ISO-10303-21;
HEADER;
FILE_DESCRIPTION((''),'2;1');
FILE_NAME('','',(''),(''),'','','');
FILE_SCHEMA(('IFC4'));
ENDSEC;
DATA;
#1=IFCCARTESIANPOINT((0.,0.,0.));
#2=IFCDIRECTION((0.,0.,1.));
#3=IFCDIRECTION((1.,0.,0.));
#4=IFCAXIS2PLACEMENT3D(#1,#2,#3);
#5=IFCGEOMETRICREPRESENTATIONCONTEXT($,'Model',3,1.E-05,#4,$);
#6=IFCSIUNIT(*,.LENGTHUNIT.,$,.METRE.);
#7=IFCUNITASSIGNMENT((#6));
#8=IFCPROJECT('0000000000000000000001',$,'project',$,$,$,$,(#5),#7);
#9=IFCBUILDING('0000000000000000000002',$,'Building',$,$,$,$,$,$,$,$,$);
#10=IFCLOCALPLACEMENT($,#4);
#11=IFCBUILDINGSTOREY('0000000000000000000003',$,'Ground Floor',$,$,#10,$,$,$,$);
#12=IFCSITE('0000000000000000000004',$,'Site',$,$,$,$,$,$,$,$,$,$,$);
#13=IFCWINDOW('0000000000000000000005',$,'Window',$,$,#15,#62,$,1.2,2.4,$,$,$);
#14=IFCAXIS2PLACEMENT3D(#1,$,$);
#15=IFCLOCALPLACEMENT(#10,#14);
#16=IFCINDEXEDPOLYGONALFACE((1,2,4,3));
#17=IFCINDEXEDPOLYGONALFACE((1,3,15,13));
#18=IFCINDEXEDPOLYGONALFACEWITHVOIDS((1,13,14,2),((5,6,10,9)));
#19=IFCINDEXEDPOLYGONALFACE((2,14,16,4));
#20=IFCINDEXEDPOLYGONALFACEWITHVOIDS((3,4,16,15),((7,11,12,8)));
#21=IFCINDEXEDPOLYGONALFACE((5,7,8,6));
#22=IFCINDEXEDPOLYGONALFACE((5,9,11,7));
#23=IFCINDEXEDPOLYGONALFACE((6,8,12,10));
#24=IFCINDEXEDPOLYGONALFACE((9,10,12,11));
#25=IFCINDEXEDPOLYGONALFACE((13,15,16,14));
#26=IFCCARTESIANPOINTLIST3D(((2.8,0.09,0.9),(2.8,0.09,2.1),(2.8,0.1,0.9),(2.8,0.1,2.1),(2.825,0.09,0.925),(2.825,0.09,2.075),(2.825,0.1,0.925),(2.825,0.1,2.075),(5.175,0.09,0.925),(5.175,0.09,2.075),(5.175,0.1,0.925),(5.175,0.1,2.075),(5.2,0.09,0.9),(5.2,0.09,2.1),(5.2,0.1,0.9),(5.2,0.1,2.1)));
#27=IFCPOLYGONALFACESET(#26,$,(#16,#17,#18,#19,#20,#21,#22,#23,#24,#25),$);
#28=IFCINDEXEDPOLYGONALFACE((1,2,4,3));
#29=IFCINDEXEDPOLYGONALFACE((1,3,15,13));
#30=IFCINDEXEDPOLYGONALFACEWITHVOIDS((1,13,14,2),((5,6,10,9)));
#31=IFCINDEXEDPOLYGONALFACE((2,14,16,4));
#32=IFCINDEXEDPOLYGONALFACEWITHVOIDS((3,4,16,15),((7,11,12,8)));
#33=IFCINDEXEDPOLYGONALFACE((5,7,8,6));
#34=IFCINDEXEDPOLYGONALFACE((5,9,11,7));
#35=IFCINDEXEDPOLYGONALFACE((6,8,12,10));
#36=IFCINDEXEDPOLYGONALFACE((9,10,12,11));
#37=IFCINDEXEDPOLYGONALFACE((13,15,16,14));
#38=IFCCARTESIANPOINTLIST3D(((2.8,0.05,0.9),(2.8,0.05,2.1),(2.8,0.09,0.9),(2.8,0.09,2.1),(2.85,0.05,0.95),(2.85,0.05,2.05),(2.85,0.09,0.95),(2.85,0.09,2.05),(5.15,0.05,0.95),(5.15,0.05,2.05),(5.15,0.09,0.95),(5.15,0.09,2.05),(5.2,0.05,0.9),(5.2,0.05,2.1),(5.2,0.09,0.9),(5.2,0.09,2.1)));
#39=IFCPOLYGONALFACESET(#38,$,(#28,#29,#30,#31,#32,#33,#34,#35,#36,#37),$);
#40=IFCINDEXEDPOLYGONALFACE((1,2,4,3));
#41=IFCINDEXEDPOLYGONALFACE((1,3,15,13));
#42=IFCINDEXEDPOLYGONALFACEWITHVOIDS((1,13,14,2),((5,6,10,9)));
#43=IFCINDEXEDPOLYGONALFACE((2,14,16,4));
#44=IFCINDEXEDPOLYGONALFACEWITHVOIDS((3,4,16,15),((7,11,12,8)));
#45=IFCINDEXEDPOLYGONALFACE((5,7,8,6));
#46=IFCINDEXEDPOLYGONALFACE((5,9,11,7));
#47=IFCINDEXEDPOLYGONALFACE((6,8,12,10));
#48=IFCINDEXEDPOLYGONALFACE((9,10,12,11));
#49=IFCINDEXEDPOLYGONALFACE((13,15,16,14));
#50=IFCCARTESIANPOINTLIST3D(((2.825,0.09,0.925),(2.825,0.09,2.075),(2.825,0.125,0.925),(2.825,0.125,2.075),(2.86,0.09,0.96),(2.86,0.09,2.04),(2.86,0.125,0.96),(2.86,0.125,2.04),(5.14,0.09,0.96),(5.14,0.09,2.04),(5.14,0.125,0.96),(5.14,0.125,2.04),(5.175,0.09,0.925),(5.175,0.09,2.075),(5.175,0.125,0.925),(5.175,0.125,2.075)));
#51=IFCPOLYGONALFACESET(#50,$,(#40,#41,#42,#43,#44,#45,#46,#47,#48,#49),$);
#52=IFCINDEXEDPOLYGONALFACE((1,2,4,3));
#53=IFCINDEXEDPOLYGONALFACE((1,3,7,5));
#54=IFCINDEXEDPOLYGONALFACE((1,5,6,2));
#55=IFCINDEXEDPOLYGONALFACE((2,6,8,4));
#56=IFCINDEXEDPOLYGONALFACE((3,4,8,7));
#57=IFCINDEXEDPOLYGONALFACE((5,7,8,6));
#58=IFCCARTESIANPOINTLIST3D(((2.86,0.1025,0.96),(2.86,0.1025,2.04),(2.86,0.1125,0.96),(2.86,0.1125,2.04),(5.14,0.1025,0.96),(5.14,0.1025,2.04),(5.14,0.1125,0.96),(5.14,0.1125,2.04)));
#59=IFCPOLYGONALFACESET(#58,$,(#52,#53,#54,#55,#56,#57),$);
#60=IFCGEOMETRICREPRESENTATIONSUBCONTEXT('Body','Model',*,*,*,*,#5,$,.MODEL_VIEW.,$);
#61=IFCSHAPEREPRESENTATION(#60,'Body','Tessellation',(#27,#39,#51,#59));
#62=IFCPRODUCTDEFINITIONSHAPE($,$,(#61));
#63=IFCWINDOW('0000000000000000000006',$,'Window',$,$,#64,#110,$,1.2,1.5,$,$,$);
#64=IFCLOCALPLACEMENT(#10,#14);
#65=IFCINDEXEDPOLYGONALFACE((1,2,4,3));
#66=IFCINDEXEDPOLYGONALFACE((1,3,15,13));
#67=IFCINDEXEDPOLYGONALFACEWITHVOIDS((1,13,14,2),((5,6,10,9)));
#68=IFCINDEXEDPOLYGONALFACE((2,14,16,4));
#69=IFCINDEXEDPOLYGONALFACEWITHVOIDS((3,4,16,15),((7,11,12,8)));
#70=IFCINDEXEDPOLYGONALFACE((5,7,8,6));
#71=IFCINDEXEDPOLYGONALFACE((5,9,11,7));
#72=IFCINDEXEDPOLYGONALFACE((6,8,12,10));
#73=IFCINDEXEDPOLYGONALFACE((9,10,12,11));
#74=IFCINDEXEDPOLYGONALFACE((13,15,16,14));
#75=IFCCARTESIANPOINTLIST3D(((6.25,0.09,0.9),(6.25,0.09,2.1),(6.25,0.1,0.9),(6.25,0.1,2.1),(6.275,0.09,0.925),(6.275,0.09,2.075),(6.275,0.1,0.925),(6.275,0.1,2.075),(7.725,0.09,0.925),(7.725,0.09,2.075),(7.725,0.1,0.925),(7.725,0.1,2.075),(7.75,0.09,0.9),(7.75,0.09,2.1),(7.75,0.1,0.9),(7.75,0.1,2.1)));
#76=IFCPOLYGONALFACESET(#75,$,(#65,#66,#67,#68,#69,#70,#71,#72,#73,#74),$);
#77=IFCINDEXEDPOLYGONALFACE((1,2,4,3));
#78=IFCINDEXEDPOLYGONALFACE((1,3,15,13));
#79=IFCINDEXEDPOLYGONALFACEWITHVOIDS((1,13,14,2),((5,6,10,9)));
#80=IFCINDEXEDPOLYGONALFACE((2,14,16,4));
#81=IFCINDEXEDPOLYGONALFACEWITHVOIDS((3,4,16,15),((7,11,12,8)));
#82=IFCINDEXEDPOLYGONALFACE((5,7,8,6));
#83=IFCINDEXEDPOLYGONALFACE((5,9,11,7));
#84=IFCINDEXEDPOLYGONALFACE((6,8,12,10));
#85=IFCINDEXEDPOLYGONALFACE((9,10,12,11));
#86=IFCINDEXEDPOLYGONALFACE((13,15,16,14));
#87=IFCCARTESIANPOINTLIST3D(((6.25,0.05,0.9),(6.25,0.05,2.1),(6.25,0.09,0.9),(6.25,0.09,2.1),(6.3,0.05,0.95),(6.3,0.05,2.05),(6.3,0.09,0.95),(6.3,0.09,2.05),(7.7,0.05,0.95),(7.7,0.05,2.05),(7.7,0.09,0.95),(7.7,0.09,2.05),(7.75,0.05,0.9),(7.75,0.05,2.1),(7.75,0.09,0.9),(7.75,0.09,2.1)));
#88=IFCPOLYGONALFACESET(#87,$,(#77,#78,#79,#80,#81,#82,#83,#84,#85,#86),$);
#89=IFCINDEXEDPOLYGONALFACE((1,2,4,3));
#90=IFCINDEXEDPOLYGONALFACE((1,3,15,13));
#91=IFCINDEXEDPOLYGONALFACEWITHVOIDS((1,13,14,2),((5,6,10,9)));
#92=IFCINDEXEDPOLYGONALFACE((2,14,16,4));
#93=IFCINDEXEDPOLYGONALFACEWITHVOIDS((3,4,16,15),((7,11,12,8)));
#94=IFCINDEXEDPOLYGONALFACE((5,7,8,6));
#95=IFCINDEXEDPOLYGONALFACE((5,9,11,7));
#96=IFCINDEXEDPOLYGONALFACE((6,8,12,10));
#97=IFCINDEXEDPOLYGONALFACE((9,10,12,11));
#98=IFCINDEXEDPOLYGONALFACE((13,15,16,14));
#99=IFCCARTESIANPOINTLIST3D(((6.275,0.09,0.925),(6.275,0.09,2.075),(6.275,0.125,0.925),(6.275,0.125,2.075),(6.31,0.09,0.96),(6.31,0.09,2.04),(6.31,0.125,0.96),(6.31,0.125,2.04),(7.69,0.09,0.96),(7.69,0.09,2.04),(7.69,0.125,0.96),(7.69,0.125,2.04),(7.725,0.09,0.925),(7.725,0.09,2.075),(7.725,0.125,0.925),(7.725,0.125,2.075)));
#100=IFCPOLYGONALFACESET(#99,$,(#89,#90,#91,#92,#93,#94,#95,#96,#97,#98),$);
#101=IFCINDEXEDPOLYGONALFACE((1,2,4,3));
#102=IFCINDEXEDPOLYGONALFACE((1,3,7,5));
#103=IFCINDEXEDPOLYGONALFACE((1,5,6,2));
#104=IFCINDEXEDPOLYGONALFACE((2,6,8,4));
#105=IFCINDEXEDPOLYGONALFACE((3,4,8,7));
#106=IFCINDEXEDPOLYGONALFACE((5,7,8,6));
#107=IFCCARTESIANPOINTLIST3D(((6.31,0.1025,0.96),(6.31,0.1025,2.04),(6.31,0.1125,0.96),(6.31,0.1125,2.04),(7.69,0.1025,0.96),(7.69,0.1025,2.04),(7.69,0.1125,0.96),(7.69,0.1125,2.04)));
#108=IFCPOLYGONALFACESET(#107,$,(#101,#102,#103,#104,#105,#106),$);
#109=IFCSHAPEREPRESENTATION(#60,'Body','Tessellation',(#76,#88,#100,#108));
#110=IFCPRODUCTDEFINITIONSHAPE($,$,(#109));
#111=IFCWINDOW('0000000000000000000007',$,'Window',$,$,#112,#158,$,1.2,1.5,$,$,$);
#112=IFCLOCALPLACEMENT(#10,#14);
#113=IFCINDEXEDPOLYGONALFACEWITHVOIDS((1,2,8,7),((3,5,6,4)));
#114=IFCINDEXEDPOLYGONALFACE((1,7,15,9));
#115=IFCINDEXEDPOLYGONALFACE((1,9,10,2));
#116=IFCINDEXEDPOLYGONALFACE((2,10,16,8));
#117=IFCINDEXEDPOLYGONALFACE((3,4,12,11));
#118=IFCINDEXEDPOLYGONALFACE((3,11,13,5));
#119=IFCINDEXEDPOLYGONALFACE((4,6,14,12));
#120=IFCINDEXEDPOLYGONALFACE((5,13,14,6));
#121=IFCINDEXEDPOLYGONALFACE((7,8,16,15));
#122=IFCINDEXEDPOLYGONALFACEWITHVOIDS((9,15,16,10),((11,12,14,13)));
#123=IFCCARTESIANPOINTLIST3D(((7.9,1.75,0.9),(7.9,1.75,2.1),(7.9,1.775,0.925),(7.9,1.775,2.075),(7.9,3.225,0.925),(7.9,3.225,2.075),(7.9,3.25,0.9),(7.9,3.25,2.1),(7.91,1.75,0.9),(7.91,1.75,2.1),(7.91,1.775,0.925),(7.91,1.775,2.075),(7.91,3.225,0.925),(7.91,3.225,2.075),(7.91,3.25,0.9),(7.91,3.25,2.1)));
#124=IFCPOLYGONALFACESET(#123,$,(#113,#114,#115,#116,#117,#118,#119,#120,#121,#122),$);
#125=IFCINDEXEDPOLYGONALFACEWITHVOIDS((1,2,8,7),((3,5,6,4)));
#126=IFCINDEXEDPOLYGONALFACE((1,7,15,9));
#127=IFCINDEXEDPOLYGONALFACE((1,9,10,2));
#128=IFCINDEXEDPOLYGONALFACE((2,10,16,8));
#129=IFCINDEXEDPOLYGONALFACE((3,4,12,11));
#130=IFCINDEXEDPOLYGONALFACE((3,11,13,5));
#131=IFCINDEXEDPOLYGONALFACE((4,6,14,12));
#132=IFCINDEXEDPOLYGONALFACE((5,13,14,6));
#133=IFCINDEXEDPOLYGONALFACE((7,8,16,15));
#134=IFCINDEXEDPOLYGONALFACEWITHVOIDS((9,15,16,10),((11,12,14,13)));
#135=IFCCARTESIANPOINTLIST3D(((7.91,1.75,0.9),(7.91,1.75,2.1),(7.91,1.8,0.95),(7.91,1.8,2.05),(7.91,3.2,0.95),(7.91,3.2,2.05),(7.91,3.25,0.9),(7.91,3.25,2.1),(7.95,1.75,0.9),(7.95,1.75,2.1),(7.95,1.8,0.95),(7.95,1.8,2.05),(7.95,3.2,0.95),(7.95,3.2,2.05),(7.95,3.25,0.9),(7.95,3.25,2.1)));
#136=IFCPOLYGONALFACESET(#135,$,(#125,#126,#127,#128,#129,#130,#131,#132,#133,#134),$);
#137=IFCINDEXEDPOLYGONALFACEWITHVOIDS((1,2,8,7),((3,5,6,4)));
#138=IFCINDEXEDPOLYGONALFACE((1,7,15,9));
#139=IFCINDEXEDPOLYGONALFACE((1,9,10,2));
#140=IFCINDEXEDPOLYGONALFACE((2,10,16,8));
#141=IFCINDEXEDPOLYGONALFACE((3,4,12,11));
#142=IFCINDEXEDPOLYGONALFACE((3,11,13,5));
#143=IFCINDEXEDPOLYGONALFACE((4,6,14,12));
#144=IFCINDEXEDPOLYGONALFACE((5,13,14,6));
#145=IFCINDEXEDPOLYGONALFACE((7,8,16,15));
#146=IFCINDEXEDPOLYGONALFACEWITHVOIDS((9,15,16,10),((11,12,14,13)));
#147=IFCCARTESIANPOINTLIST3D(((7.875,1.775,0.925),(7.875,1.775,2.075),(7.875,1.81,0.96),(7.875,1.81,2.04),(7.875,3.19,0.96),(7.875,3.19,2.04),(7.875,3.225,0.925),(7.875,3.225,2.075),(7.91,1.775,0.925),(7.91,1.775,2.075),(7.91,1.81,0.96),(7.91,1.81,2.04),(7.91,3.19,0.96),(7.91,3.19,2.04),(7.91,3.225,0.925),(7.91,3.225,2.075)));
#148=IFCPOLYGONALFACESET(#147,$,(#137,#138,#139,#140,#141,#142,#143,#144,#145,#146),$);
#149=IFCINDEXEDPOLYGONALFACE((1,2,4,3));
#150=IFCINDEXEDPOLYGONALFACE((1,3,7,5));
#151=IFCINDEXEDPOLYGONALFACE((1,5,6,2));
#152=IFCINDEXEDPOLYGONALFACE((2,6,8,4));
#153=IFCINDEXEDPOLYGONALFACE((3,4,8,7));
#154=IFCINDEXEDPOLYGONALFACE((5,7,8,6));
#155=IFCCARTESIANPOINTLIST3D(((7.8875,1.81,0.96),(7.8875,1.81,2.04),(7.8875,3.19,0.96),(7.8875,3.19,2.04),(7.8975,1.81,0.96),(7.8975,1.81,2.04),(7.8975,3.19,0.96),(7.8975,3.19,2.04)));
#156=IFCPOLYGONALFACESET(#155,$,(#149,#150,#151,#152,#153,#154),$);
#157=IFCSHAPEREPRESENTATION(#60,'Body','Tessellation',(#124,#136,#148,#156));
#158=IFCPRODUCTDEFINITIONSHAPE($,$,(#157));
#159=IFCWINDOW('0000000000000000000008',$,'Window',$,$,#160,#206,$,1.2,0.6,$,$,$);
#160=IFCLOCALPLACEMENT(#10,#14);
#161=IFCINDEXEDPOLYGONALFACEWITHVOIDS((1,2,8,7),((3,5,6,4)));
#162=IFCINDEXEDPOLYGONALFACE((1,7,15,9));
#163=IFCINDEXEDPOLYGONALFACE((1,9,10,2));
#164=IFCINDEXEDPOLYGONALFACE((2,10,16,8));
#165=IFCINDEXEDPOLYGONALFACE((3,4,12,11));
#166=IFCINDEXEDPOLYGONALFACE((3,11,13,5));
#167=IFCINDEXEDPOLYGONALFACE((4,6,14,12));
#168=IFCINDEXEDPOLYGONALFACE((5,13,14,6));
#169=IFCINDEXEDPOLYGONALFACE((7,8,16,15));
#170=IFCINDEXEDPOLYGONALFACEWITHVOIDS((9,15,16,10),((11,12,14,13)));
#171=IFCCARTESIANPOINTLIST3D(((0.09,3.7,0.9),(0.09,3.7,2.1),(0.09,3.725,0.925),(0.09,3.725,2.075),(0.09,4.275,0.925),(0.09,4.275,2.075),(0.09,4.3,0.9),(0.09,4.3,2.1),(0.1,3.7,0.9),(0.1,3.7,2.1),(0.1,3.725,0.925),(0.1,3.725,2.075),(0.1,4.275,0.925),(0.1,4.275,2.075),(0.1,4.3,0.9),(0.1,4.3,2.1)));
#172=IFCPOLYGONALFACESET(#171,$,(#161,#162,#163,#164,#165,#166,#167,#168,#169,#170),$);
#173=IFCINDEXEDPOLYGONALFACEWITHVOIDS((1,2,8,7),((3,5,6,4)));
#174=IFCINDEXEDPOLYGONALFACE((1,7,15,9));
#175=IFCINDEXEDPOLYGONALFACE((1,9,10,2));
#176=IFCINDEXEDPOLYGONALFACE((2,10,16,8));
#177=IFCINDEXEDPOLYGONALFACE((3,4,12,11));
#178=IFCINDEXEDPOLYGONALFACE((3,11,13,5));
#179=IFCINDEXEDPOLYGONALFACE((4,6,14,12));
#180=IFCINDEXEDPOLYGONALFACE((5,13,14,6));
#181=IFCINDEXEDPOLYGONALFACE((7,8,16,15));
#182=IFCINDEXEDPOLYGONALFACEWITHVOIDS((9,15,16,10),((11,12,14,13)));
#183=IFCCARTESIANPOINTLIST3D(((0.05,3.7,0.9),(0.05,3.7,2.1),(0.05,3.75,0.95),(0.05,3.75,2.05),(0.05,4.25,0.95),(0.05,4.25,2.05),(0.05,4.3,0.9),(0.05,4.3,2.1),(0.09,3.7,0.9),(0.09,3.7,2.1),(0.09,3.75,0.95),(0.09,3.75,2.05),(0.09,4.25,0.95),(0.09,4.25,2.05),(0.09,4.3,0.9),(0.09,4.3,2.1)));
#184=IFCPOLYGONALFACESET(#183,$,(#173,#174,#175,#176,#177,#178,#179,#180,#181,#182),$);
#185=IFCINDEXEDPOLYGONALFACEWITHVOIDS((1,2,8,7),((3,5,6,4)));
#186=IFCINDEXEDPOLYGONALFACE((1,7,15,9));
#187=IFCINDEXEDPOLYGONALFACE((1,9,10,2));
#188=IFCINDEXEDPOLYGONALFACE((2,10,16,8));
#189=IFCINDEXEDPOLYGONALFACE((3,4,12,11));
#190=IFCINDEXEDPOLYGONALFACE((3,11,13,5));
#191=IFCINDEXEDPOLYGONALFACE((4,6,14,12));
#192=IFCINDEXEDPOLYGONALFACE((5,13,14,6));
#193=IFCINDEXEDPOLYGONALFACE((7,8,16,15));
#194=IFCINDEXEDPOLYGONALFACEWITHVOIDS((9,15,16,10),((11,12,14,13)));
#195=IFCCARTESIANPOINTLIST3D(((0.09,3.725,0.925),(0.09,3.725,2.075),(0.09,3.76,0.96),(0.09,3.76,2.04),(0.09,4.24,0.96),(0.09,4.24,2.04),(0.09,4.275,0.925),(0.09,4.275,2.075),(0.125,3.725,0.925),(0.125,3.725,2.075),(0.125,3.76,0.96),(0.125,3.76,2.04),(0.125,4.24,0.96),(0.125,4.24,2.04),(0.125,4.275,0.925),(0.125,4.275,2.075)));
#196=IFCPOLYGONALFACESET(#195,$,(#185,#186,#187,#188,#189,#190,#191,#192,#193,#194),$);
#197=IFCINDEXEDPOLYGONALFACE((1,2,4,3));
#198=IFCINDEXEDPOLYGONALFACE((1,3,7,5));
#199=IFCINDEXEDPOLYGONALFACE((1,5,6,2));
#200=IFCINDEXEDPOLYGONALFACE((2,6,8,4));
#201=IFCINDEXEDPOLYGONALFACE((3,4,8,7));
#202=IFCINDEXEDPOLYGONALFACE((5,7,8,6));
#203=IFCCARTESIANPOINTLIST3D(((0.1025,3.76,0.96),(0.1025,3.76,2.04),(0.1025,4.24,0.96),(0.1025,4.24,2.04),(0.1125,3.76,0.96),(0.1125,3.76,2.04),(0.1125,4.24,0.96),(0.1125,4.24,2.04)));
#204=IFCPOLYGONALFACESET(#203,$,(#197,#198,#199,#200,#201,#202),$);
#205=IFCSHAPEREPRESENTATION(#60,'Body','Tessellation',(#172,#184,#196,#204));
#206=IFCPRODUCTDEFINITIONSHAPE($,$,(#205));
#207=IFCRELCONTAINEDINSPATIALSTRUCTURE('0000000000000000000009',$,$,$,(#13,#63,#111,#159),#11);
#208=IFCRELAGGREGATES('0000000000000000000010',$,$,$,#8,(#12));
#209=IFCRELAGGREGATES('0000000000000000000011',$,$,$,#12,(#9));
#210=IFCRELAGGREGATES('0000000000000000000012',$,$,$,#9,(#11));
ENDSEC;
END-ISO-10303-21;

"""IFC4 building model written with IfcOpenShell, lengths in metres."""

from ifc_helpers import new_model, si_unit, frame, origin_with_axes, place, context, subcontext, project, spatial, line, indexed_curve, outline, extrude, element, save


model = new_model("IFC4")

# Units and contexts
model_context = context("Model", 3, precision=1e-05, world=origin_with_axes())
body_context = subcontext(model_context, "Body", "Model", "MODEL_VIEW")
ifc_project = project(units=[si_unit("LENGTHUNIT", "METRE")], contexts=[model_context])

# Site, building, storey
site = spatial("IfcSite", under=ifc_project, Name="Site")
building = spatial("IfcBuilding", under=site, Name="Building")
storey_placement = place(None, origin_with_axes())
storey = spatial("IfcBuildingStorey", under=building, at=storey_placement, Name="Ground Floor")

# Windows
window_1_placement = place(storey_placement, frame((2.8, 0.0, 0.9), z_axis=(0.0, 0.0, 1.0), x_axis=(1.0, 0.0, 0.0)))
element("IfcWindow", 1, at=window_1_placement, inside=storey, Name="Window", OverallHeight=1.2, OverallWidth=2.4, context=body_context, shape_type="SweptSolid", body=[
    extrude(outline(indexed_curve([(0.0, 0.0), (2.4, 0.0), (2.4, 1.2), (0.0, 1.2)], segments=[line(1, 2, 3, 4, 1)]), holes=[indexed_curve([(0.025, 0.025), (2.375, 0.025), (2.375, 1.175), (0.025, 1.175)], segments=[line(1, 2, 3, 4, 1)])]), frame((0.0, 0.09, 0.0), z_axis=(0.0, -1.0, 0.0), x_axis=(1.0, 0.0, 0.0)), (0.0, 0.0, -1.0), 0.01),
    extrude(outline(indexed_curve([(0.0, 0.0), (2.4, 0.0), (2.4, 1.2), (0.0, 1.2)], segments=[line(1, 2, 3, 4, 1)]), holes=[indexed_curve([(0.05, 0.05), (2.35, 0.05), (2.35, 1.15), (0.05, 1.15)], segments=[line(1, 2, 3, 4, 1)])]), frame((0.0, 0.05, 0.0), z_axis=(0.0, -1.0, 0.0), x_axis=(1.0, 0.0, 0.0)), (0.0, 0.0, -1.0), 0.04),
    extrude(outline(indexed_curve([(0.0, 0.0), (2.35, 0.0), (2.35, 1.15), (0.0, 1.15)], segments=[line(1, 2, 3, 4, 1)]), holes=[indexed_curve([(0.035, 0.035), (2.315, 0.035), (2.315, 1.115), (0.035, 1.115)], segments=[line(1, 2, 3, 4, 1)])]), frame((0.025, 0.09, 0.025), z_axis=(0.0, -1.0, 0.0), x_axis=(1.0, 0.0, 0.0)), (0.0, 0.0, -1.0), 0.035),
    extrude(outline(indexed_curve([(0.035, 0.035), (2.315, 0.035), (2.315, 1.115), (0.035, 1.115)], segments=[line(1, 2, 3, 4, 1)])), frame((0.025, 0.1025, 0.025), z_axis=(0.0, -1.0, 0.0), x_axis=(1.0, 0.0, 0.0)), (0.0, 0.0, -1.0), 0.01),
])
for number, where, z_axis, x_axis, name in (
    (2, (6.25, 0.0, 0.9), (0.0, 0.0, 1.0), (1.0, 0.0, 0.0), "Window"),
    (3, (8.0, 1.75, 0.9), (0.0, 0.0, 1.0), (0.0, 1.0, 0.0), "Window"),
):
    element("IfcWindow", number, at=place(storey_placement, frame(where, z_axis=z_axis, x_axis=x_axis)), inside=storey, Name=name, OverallHeight=1.2, OverallWidth=1.5, context=body_context, shape_type="SweptSolid", body=[
        extrude(outline(indexed_curve([(0.0, 0.0), (1.5, 0.0), (1.5, 1.2), (0.0, 1.2)], segments=[line(1, 2, 3, 4, 1)]), holes=[indexed_curve([(0.025, 0.025), (1.475, 0.025), (1.475, 1.175), (0.025, 1.175)], segments=[line(1, 2, 3, 4, 1)])]), frame((0.0, 0.09, 0.0), z_axis=(0.0, -1.0, 0.0), x_axis=(1.0, 0.0, 0.0)), (0.0, 0.0, -1.0), 0.01),
        extrude(outline(indexed_curve([(0.0, 0.0), (1.5, 0.0), (1.5, 1.2), (0.0, 1.2)], segments=[line(1, 2, 3, 4, 1)]), holes=[indexed_curve([(0.05, 0.05), (1.45, 0.05), (1.45, 1.15), (0.05, 1.15)], segments=[line(1, 2, 3, 4, 1)])]), frame((0.0, 0.05, 0.0), z_axis=(0.0, -1.0, 0.0), x_axis=(1.0, 0.0, 0.0)), (0.0, 0.0, -1.0), 0.04),
        extrude(outline(indexed_curve([(0.0, 0.0), (1.45, 0.0), (1.45, 1.15), (0.0, 1.15)], segments=[line(1, 2, 3, 4, 1)]), holes=[indexed_curve([(0.035, 0.035), (1.415, 0.035), (1.415, 1.115), (0.035, 1.115)], segments=[line(1, 2, 3, 4, 1)])]), frame((0.025, 0.09, 0.025), z_axis=(0.0, -1.0, 0.0), x_axis=(1.0, 0.0, 0.0)), (0.0, 0.0, -1.0), 0.035),
        extrude(outline(indexed_curve([(0.035, 0.035), (1.415, 0.035), (1.415, 1.115), (0.035, 1.115)], segments=[line(1, 2, 3, 4, 1)])), frame((0.025, 0.1025, 0.025), z_axis=(0.0, -1.0, 0.0), x_axis=(1.0, 0.0, 0.0)), (0.0, 0.0, -1.0), 0.01),
    ])
window_2_placement = place(storey_placement, frame((0.0, 4.3, 0.9), z_axis=(0.0, 0.0, 1.0), x_axis=(0.0, -1.0, 0.0)))
element("IfcWindow", 4, at=window_2_placement, inside=storey, Name="Window", OverallHeight=1.2, OverallWidth=0.6, context=body_context, shape_type="SweptSolid", body=[
    extrude(outline(indexed_curve([(0.0, 0.0), (0.6, 0.0), (0.6, 1.2), (0.0, 1.2)], segments=[line(1, 2, 3, 4, 1)]), holes=[indexed_curve([(0.025, 0.025), (0.575, 0.025), (0.575, 1.175), (0.025, 1.175)], segments=[line(1, 2, 3, 4, 1)])]), frame((0.0, 0.09, 0.0), z_axis=(0.0, -1.0, 0.0), x_axis=(1.0, 0.0, 0.0)), (0.0, 0.0, -1.0), 0.01),
    extrude(outline(indexed_curve([(0.0, 0.0), (0.6, 0.0), (0.6, 1.2), (0.0, 1.2)], segments=[line(1, 2, 3, 4, 1)]), holes=[indexed_curve([(0.05, 0.05), (0.55, 0.05), (0.55, 1.15), (0.05, 1.15)], segments=[line(1, 2, 3, 4, 1)])]), frame((0.0, 0.05, 0.0), z_axis=(0.0, -1.0, 0.0), x_axis=(1.0, 0.0, 0.0)), (0.0, 0.0, -1.0), 0.04),
    extrude(outline(indexed_curve([(0.0, 0.0), (0.55, 0.0), (0.55, 1.15), (0.0, 1.15)], segments=[line(1, 2, 3, 4, 1)]), holes=[indexed_curve([(0.035, 0.035), (0.515, 0.035), (0.515, 1.115), (0.035, 1.115)], segments=[line(1, 2, 3, 4, 1)])]), frame((0.025, 0.09, 0.025), z_axis=(0.0, -1.0, 0.0), x_axis=(1.0, 0.0, 0.0)), (0.0, 0.0, -1.0), 0.035),
    extrude(outline(indexed_curve([(0.035, 0.035), (0.515, 0.035), (0.515, 1.115), (0.035, 1.115)], segments=[line(1, 2, 3, 4, 1)])), frame((0.025, 0.1025, 0.025), z_axis=(0.0, -1.0, 0.0), x_axis=(1.0, 0.0, 0.0)), (0.0, 0.0, -1.0), 0.01),
])

save(model, "model.ifc")
